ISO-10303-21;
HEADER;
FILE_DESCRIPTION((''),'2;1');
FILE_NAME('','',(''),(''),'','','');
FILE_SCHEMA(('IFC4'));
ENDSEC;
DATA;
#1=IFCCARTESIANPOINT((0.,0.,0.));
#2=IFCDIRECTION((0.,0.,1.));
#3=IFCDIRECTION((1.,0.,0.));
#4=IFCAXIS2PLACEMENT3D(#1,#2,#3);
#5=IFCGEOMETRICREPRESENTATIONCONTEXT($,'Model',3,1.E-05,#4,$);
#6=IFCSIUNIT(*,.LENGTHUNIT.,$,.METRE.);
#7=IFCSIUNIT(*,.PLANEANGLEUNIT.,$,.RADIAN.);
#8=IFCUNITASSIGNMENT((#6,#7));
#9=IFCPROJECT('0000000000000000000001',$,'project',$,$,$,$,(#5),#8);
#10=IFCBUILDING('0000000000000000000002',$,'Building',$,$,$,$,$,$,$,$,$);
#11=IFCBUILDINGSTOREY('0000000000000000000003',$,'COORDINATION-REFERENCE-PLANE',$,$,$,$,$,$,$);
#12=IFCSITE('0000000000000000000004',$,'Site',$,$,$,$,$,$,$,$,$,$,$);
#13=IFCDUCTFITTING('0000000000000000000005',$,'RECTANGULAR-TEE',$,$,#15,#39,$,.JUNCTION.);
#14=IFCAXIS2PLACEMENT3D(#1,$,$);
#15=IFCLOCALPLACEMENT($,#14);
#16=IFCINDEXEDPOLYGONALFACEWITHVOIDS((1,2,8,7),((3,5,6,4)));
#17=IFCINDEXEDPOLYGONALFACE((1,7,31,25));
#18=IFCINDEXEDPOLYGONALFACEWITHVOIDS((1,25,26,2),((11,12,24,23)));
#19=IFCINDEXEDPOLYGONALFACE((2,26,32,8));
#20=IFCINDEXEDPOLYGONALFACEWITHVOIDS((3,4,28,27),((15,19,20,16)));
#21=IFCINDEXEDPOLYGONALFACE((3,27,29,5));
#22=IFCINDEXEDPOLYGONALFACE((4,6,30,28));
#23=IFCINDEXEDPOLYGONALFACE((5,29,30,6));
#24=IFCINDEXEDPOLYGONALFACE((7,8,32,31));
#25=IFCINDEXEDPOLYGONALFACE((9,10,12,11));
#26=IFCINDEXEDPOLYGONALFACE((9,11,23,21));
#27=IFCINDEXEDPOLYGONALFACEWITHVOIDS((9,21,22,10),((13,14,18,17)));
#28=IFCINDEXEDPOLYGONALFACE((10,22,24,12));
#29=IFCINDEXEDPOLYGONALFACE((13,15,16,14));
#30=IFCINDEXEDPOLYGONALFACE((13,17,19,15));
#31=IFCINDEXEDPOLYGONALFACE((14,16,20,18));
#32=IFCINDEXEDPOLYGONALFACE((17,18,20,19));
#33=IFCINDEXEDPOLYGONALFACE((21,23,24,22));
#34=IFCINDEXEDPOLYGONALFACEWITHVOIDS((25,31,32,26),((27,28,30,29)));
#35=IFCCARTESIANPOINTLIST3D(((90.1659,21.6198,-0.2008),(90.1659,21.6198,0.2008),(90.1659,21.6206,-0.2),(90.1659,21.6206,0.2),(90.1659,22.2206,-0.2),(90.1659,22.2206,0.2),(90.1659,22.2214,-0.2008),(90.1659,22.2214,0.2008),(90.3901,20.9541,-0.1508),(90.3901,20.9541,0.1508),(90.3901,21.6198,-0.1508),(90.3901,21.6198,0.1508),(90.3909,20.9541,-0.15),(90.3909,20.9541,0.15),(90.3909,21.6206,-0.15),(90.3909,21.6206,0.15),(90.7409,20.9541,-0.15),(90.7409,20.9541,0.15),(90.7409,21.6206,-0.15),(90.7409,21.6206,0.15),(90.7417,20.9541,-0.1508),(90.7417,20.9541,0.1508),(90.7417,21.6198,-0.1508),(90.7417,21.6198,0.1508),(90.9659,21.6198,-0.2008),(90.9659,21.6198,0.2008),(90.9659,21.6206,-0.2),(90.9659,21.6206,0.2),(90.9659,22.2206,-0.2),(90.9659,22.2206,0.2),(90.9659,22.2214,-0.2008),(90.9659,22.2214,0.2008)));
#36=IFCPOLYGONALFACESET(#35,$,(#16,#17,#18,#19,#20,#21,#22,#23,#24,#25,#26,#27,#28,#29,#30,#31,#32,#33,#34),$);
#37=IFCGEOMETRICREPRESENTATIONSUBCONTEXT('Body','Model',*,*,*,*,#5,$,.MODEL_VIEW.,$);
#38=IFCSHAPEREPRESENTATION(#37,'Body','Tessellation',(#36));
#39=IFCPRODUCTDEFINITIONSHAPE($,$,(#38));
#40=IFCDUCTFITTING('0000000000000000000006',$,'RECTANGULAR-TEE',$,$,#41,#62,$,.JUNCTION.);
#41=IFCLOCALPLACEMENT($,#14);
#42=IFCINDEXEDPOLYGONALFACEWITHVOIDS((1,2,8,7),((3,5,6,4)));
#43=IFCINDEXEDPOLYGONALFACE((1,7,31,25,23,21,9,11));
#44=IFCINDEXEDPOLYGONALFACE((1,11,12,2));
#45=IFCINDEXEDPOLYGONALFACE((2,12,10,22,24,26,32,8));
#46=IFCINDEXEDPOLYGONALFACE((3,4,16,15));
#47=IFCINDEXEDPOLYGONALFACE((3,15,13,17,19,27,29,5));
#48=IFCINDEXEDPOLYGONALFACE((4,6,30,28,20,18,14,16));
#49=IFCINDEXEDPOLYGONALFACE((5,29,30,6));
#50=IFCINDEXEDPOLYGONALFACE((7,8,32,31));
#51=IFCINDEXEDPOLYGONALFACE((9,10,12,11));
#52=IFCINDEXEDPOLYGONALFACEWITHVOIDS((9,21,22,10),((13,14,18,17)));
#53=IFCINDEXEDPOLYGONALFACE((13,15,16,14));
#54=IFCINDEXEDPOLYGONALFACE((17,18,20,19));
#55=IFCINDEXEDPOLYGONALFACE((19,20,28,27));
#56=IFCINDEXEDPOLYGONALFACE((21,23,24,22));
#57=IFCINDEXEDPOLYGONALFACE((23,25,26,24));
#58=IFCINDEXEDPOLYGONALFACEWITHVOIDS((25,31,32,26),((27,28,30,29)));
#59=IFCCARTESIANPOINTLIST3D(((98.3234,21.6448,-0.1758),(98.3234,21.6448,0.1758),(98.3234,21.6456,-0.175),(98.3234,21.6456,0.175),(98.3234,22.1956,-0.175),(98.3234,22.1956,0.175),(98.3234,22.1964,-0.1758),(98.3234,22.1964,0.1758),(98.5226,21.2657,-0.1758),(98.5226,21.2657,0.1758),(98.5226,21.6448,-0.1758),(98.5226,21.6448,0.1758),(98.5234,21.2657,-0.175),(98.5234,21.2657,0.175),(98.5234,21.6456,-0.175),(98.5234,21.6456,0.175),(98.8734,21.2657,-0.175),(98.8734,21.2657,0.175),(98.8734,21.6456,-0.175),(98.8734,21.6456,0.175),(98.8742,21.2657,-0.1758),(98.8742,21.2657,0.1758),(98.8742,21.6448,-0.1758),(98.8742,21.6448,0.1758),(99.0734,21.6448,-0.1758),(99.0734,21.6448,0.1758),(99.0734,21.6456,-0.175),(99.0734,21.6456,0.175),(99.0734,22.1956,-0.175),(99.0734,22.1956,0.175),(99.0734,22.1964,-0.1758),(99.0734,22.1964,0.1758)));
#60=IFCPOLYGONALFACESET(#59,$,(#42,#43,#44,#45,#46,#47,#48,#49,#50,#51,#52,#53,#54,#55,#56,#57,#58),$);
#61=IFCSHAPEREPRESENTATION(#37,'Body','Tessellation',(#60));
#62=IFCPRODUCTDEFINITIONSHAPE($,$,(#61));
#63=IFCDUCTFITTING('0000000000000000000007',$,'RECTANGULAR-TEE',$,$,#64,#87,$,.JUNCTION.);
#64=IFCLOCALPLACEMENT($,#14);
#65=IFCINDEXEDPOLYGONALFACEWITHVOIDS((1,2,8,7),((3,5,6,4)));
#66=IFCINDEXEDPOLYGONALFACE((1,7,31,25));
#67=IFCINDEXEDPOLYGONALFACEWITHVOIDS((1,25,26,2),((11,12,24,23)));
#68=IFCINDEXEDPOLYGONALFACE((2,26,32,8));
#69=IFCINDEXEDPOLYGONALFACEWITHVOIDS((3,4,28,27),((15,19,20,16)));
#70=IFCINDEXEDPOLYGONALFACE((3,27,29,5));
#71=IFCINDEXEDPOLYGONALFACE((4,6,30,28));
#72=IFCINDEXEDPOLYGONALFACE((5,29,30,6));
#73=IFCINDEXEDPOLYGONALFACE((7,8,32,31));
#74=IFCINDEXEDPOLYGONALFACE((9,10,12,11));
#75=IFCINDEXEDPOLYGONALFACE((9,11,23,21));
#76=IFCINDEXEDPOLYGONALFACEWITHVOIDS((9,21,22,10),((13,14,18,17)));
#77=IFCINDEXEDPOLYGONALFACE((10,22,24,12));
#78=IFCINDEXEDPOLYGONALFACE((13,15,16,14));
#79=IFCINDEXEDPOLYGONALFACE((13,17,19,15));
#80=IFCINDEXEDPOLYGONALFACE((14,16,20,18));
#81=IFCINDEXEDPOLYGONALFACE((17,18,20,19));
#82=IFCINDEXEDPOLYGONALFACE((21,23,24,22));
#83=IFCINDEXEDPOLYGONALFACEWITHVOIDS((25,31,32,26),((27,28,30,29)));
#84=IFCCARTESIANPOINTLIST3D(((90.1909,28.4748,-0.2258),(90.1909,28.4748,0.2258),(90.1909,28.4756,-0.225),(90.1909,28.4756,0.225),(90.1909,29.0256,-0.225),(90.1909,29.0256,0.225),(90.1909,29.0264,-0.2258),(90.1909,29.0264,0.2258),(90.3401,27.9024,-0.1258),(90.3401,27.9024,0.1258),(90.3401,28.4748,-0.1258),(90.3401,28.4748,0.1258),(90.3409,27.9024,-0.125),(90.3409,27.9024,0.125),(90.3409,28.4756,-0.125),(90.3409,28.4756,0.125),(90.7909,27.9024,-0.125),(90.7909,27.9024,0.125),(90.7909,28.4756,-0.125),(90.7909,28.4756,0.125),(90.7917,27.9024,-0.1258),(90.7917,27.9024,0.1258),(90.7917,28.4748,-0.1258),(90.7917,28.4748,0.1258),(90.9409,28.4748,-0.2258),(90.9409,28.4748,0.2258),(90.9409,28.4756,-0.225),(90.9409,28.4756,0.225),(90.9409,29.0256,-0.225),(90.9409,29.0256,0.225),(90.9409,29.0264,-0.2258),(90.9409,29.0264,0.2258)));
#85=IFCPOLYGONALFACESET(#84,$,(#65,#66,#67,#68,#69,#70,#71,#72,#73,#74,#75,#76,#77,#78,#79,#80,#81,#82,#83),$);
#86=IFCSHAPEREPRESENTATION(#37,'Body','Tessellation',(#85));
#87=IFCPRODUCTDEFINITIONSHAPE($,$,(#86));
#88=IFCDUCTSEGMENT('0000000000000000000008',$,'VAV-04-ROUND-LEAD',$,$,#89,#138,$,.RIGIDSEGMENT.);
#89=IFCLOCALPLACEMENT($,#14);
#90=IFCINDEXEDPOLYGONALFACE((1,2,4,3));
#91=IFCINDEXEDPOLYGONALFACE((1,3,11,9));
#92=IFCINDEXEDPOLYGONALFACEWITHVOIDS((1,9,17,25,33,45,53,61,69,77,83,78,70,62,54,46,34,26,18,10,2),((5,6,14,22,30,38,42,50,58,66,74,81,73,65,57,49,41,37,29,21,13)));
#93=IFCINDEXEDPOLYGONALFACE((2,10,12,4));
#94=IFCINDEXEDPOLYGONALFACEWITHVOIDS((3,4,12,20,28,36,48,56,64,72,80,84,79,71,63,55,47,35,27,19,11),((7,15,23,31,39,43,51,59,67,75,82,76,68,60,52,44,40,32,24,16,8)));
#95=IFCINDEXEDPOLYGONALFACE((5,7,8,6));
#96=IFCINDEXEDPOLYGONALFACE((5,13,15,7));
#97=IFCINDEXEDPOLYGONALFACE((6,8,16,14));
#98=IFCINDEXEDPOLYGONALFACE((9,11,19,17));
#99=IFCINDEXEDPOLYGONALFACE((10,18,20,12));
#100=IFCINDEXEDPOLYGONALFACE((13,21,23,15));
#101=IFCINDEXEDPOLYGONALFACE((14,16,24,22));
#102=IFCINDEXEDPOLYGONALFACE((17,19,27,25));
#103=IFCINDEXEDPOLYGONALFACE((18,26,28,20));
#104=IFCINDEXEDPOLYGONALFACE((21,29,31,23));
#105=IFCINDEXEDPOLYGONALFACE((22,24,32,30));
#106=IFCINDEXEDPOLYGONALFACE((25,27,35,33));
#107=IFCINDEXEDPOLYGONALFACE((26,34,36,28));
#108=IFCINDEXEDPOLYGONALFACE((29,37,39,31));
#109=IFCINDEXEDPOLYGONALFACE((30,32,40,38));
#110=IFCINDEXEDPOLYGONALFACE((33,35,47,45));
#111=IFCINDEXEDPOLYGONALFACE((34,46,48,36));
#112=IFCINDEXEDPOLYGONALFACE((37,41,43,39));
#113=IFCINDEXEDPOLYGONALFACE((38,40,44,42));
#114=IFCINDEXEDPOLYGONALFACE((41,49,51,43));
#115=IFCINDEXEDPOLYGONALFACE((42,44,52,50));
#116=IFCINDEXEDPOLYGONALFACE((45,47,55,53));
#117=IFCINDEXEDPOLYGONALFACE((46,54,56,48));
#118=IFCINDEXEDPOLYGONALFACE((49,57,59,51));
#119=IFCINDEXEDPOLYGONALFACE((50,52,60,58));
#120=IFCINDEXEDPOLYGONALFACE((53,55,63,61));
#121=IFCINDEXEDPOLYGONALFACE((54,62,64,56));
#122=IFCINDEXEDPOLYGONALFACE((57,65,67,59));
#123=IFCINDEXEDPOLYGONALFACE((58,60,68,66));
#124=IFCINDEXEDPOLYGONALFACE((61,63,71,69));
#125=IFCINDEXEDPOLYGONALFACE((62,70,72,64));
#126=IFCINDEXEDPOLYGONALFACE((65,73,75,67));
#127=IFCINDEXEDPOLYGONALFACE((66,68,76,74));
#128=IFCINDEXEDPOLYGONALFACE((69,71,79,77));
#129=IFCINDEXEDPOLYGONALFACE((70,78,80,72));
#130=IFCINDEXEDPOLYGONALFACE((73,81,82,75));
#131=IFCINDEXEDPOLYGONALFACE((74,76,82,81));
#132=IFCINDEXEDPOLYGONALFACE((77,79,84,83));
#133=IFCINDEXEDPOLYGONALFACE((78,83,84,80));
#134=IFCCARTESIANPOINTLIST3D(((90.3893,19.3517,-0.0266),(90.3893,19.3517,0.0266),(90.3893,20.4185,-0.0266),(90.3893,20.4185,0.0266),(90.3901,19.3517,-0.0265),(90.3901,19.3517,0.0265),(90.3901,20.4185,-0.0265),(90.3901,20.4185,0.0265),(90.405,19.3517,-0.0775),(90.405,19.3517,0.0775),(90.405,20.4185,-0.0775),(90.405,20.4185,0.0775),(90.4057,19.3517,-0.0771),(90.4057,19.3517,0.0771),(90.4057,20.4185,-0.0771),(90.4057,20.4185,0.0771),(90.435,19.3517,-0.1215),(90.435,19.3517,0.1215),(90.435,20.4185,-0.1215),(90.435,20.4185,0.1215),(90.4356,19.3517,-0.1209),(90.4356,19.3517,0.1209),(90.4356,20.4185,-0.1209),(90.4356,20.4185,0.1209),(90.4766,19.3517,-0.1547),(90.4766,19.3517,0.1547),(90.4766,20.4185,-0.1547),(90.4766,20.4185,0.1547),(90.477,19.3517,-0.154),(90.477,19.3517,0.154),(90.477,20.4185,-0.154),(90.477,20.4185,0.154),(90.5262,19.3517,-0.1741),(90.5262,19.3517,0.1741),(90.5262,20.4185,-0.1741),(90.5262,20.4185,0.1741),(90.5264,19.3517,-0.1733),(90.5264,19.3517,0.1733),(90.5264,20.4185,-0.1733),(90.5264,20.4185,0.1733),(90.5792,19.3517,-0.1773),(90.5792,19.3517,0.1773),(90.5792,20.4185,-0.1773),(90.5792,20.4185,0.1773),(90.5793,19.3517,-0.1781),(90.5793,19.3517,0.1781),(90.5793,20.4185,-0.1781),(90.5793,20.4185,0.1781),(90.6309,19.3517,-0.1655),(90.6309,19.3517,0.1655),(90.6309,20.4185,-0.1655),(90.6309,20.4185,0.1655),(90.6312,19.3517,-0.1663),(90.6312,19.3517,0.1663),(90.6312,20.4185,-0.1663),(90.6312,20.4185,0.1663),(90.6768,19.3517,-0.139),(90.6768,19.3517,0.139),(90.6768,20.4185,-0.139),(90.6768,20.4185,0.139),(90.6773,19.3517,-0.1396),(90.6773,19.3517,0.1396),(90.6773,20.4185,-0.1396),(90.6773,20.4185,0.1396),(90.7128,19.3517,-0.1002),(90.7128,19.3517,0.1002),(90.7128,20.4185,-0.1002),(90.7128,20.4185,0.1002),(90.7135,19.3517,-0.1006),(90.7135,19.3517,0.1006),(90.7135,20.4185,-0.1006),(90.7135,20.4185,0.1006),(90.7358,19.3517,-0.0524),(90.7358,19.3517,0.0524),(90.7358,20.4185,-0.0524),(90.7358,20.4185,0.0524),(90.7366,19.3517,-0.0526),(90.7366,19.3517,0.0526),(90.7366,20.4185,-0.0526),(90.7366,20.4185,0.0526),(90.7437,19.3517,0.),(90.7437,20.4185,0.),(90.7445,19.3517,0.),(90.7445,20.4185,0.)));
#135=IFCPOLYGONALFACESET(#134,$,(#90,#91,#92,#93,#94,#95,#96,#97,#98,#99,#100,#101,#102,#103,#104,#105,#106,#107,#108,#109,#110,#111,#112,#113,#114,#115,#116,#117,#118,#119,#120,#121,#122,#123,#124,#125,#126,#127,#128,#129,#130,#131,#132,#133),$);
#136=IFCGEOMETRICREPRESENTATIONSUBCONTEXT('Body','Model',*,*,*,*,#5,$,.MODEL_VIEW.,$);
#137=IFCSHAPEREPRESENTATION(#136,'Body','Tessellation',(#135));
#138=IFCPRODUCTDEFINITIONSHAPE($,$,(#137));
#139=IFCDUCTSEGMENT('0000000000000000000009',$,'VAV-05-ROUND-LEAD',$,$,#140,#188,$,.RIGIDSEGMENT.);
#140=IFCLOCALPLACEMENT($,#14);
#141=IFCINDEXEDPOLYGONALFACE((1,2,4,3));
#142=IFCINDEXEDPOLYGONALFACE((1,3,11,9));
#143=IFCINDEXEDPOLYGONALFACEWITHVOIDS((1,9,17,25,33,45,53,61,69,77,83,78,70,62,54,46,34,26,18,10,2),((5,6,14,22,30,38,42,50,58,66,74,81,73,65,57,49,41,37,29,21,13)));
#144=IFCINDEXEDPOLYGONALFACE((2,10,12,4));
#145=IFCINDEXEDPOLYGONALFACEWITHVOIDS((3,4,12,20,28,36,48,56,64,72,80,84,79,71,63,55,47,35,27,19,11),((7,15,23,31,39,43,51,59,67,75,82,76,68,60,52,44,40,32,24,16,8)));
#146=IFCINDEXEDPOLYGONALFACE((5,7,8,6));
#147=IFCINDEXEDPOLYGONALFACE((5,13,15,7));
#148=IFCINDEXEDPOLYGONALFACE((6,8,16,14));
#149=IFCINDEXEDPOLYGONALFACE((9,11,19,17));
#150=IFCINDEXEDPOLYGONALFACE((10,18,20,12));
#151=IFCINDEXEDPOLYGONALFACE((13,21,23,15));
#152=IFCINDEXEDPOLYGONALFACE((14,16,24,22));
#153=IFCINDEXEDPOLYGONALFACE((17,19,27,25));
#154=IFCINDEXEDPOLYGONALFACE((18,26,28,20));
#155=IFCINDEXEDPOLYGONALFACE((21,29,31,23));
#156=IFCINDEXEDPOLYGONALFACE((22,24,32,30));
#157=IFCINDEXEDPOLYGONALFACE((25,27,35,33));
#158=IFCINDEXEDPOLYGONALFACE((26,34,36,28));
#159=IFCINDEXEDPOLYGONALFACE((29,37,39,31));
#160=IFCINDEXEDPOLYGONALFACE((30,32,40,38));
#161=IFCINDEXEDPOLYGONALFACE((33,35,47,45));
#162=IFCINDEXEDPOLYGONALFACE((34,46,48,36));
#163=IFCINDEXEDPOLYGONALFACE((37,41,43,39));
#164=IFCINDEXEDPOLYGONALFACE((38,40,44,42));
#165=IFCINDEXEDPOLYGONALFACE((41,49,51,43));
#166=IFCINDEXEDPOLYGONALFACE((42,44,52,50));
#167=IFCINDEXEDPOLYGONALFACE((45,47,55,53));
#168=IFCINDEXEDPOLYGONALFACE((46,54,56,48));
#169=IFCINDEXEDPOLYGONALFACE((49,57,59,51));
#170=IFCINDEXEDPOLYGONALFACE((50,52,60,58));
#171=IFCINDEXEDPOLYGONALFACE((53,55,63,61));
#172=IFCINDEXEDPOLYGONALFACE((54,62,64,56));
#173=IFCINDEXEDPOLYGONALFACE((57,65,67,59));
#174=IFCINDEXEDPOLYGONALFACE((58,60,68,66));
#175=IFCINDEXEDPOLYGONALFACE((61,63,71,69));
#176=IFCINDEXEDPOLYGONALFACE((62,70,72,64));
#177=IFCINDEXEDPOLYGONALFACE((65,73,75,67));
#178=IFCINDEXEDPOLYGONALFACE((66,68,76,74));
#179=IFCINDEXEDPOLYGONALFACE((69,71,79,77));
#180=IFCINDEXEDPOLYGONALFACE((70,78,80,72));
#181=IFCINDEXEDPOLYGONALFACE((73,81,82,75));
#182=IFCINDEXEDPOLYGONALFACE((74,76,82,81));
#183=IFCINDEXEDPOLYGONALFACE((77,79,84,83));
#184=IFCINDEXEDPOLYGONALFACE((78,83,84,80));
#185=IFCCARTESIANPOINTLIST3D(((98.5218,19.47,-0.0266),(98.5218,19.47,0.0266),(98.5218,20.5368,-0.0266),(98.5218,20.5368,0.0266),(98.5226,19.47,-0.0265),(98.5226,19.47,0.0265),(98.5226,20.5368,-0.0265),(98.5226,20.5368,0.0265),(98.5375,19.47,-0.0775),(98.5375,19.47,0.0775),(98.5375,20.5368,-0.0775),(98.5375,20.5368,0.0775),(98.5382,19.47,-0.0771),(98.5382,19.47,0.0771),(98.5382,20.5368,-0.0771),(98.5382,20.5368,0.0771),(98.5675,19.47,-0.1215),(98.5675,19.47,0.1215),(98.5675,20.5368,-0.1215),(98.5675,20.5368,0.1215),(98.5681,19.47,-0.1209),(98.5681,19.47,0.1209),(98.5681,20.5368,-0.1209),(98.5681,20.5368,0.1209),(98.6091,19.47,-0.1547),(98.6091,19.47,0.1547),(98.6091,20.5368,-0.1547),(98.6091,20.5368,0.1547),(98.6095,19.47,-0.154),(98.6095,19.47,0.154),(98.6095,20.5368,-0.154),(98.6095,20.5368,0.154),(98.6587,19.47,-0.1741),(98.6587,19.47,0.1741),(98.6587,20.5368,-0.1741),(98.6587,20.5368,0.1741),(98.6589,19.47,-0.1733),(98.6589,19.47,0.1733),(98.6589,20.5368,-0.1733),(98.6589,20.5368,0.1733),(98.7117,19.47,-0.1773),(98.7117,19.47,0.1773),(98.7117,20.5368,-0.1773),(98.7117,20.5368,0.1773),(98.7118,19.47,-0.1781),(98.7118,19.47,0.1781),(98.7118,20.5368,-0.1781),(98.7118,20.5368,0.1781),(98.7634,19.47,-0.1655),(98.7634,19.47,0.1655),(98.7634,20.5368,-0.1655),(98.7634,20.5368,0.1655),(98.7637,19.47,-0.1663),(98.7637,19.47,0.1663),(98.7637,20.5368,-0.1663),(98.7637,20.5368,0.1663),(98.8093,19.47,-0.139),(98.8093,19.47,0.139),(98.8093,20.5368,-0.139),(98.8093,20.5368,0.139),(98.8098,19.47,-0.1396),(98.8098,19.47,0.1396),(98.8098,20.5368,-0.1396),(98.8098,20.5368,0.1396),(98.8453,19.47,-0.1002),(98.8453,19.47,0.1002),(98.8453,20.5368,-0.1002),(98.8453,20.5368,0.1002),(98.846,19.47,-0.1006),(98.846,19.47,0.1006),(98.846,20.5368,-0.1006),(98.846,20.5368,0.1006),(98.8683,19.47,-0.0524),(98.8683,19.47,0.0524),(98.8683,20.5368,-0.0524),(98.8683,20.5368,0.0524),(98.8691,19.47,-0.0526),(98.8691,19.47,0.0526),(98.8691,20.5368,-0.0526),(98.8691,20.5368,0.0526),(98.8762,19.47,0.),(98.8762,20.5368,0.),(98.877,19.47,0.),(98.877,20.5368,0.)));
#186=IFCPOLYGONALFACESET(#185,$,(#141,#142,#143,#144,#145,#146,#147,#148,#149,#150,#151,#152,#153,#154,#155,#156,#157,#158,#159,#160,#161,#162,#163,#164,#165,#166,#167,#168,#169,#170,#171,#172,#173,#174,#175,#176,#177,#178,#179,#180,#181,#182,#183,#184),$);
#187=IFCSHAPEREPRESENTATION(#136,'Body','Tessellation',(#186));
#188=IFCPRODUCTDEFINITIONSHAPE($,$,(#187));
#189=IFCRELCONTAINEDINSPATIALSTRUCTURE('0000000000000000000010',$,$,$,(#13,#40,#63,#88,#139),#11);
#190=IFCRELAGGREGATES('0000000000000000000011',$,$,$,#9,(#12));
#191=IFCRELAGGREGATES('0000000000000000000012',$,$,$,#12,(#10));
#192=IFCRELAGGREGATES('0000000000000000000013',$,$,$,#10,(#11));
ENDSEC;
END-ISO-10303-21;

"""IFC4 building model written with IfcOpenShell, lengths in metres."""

from ifc_helpers import new_model, si_unit, frame, origin, origin_with_axes, place, context, subcontext, project, spatial, rectangle, hollow_circle, extrude, boolean, element, save


model = new_model("IFC4")

# Units and contexts
model_context = context("Model", 3, precision=1e-05, world=origin_with_axes())
body_context_1 = subcontext(model_context, "Body", "Model", "MODEL_VIEW")
body_context_2 = subcontext(model_context, "Body", "Model", "MODEL_VIEW")
ifc_project = project(units=[si_unit("LENGTHUNIT", "METRE"), si_unit("PLANEANGLEUNIT", "RADIAN")], contexts=[model_context])

# Site, building, storey
site = spatial("IfcSite", under=ifc_project, Name="Site")
building = spatial("IfcBuilding", under=site, Name="Building")
storey = spatial("IfcBuildingStorey", under=building, Name="COORDINATION-REFERENCE-PLANE")

# Duct fittings
duct_fitting_1_placement = place(None, frame((90.5659, 21.9206, 0.0), z_axis=(1.0, 0.0, 0.0), x_axis=(0.0, -1.0, 0.0)))
solid_1 = boolean("UNION", extrude(rectangle(XDim=0.6, YDim=0.4), frame((0.0, 0.0, -0.4), z_axis=(0.0, 0.0, 1.0), x_axis=(1.0, 0.0, 0.0)), (0.0, 0.0, 1.0), 0.8), extrude(rectangle(XDim=0.35, YDim=0.3), frame((0.0, 0.0, 0.0), z_axis=(1.0, 0.0, 0.0), x_axis=(0.0, 0.0, -1.0)), (0.0, 0.0, 1.0), 0.9665))
element("IfcDuctFitting", 1, at=duct_fitting_1_placement, inside=storey, Name="RECTANGULAR-TEE", PredefinedType="JUNCTION", context=body_context_1, shape_type="CSG", body=[
    boolean("DIFFERENCE", boolean("UNION", extrude(rectangle(XDim=0.6016, YDim=0.4016), frame((0.0, 0.0, -0.4), z_axis=(0.0, 0.0, 1.0), x_axis=(1.0, 0.0, 0.0)), (0.0, 0.0, 1.0), 0.8), extrude(rectangle(XDim=0.3516, YDim=0.3016), frame((0.0, 0.0, 0.0), z_axis=(1.0, 0.0, 0.0), x_axis=(0.0, 0.0, -1.0)), (0.0, 0.0, 1.0), 0.9665)), solid_1),
])
duct_fitting_2_placement = place(None, frame((98.6984, 21.9206, 0.0), z_axis=(1.0, 0.0, 0.0), x_axis=(0.0, -1.0, 0.0)))
solid_2 = boolean("UNION", extrude(rectangle(XDim=0.55, YDim=0.35), frame((0.0, 0.0, -0.375), z_axis=(0.0, 0.0, 1.0), x_axis=(1.0, 0.0, 0.0)), (0.0, 0.0, 1.0), 0.75), extrude(rectangle(XDim=0.35, YDim=0.35), frame((0.0, 0.0, 0.0), z_axis=(1.0, 0.0, 0.0), x_axis=(0.0, 0.0, -1.0)), (0.0, 0.0, 1.0), 0.6549))
element("IfcDuctFitting", 2, at=duct_fitting_2_placement, inside=storey, Name="RECTANGULAR-TEE", PredefinedType="JUNCTION", context=body_context_1, shape_type="CSG", body=[
    boolean("DIFFERENCE", boolean("UNION", extrude(rectangle(XDim=0.5516, YDim=0.3516), frame((0.0, 0.0, -0.375), z_axis=(0.0, 0.0, 1.0), x_axis=(1.0, 0.0, 0.0)), (0.0, 0.0, 1.0), 0.75), extrude(rectangle(XDim=0.3516, YDim=0.3516), frame((0.0, 0.0, 0.0), z_axis=(1.0, 0.0, 0.0), x_axis=(0.0, 0.0, -1.0)), (0.0, 0.0, 1.0), 0.6549)), solid_2),
])
duct_fitting_3_placement = place(None, frame((90.5659, 28.7506, 0.0), z_axis=(1.0, 0.0, 0.0), x_axis=(0.0, -1.0, 0.0)))
solid_3 = boolean("UNION", extrude(rectangle(XDim=0.55, YDim=0.45), frame((0.0, 0.0, -0.375), z_axis=(0.0, 0.0, 1.0), x_axis=(1.0, 0.0, 0.0)), (0.0, 0.0, 1.0), 0.75), extrude(rectangle(XDim=0.45, YDim=0.25), frame((0.0, 0.0, 0.0), z_axis=(1.0, 0.0, 0.0), x_axis=(0.0, 0.0, -1.0)), (0.0, 0.0, 1.0), 0.8482))
element("IfcDuctFitting", 3, at=duct_fitting_3_placement, inside=storey, Name="RECTANGULAR-TEE", PredefinedType="JUNCTION", context=body_context_1, shape_type="CSG", body=[
    boolean("DIFFERENCE", boolean("UNION", extrude(rectangle(XDim=0.5516, YDim=0.4516), frame((0.0, 0.0, -0.375), z_axis=(0.0, 0.0, 1.0), x_axis=(1.0, 0.0, 0.0)), (0.0, 0.0, 1.0), 0.75), extrude(rectangle(XDim=0.4516, YDim=0.2516), frame((0.0, 0.0, 0.0), z_axis=(1.0, 0.0, 0.0), x_axis=(0.0, 0.0, -1.0)), (0.0, 0.0, 1.0), 0.8482)), solid_3),
])

# Duct segments
for number, where, z_axis, x_axis, name in (
    (4, (90.5659, 20.4185, 0.0), (0.0, -1.0, 0.0), (1.0, 0.0, 0.0), "VAV-04-ROUND-LEAD"),
    (5, (98.6984, 20.5368, 0.0), (0.0, -1.0, 0.0), (1.0, 0.0, 0.0), "VAV-05-ROUND-LEAD"),
):
    element("IfcDuctSegment", number, at=place(None, frame(where, z_axis=z_axis, x_axis=x_axis)), inside=storey, Name=name, PredefinedType="RIGIDSEGMENT", context=body_context_2, shape_type="SweptSolid", body=[
        extrude(hollow_circle(Radius=0.1786, WallThickness=0.0008), origin(), (0.0, 0.0, 1.0), 1.0668),
    ])

save(model, "model.ifc")
